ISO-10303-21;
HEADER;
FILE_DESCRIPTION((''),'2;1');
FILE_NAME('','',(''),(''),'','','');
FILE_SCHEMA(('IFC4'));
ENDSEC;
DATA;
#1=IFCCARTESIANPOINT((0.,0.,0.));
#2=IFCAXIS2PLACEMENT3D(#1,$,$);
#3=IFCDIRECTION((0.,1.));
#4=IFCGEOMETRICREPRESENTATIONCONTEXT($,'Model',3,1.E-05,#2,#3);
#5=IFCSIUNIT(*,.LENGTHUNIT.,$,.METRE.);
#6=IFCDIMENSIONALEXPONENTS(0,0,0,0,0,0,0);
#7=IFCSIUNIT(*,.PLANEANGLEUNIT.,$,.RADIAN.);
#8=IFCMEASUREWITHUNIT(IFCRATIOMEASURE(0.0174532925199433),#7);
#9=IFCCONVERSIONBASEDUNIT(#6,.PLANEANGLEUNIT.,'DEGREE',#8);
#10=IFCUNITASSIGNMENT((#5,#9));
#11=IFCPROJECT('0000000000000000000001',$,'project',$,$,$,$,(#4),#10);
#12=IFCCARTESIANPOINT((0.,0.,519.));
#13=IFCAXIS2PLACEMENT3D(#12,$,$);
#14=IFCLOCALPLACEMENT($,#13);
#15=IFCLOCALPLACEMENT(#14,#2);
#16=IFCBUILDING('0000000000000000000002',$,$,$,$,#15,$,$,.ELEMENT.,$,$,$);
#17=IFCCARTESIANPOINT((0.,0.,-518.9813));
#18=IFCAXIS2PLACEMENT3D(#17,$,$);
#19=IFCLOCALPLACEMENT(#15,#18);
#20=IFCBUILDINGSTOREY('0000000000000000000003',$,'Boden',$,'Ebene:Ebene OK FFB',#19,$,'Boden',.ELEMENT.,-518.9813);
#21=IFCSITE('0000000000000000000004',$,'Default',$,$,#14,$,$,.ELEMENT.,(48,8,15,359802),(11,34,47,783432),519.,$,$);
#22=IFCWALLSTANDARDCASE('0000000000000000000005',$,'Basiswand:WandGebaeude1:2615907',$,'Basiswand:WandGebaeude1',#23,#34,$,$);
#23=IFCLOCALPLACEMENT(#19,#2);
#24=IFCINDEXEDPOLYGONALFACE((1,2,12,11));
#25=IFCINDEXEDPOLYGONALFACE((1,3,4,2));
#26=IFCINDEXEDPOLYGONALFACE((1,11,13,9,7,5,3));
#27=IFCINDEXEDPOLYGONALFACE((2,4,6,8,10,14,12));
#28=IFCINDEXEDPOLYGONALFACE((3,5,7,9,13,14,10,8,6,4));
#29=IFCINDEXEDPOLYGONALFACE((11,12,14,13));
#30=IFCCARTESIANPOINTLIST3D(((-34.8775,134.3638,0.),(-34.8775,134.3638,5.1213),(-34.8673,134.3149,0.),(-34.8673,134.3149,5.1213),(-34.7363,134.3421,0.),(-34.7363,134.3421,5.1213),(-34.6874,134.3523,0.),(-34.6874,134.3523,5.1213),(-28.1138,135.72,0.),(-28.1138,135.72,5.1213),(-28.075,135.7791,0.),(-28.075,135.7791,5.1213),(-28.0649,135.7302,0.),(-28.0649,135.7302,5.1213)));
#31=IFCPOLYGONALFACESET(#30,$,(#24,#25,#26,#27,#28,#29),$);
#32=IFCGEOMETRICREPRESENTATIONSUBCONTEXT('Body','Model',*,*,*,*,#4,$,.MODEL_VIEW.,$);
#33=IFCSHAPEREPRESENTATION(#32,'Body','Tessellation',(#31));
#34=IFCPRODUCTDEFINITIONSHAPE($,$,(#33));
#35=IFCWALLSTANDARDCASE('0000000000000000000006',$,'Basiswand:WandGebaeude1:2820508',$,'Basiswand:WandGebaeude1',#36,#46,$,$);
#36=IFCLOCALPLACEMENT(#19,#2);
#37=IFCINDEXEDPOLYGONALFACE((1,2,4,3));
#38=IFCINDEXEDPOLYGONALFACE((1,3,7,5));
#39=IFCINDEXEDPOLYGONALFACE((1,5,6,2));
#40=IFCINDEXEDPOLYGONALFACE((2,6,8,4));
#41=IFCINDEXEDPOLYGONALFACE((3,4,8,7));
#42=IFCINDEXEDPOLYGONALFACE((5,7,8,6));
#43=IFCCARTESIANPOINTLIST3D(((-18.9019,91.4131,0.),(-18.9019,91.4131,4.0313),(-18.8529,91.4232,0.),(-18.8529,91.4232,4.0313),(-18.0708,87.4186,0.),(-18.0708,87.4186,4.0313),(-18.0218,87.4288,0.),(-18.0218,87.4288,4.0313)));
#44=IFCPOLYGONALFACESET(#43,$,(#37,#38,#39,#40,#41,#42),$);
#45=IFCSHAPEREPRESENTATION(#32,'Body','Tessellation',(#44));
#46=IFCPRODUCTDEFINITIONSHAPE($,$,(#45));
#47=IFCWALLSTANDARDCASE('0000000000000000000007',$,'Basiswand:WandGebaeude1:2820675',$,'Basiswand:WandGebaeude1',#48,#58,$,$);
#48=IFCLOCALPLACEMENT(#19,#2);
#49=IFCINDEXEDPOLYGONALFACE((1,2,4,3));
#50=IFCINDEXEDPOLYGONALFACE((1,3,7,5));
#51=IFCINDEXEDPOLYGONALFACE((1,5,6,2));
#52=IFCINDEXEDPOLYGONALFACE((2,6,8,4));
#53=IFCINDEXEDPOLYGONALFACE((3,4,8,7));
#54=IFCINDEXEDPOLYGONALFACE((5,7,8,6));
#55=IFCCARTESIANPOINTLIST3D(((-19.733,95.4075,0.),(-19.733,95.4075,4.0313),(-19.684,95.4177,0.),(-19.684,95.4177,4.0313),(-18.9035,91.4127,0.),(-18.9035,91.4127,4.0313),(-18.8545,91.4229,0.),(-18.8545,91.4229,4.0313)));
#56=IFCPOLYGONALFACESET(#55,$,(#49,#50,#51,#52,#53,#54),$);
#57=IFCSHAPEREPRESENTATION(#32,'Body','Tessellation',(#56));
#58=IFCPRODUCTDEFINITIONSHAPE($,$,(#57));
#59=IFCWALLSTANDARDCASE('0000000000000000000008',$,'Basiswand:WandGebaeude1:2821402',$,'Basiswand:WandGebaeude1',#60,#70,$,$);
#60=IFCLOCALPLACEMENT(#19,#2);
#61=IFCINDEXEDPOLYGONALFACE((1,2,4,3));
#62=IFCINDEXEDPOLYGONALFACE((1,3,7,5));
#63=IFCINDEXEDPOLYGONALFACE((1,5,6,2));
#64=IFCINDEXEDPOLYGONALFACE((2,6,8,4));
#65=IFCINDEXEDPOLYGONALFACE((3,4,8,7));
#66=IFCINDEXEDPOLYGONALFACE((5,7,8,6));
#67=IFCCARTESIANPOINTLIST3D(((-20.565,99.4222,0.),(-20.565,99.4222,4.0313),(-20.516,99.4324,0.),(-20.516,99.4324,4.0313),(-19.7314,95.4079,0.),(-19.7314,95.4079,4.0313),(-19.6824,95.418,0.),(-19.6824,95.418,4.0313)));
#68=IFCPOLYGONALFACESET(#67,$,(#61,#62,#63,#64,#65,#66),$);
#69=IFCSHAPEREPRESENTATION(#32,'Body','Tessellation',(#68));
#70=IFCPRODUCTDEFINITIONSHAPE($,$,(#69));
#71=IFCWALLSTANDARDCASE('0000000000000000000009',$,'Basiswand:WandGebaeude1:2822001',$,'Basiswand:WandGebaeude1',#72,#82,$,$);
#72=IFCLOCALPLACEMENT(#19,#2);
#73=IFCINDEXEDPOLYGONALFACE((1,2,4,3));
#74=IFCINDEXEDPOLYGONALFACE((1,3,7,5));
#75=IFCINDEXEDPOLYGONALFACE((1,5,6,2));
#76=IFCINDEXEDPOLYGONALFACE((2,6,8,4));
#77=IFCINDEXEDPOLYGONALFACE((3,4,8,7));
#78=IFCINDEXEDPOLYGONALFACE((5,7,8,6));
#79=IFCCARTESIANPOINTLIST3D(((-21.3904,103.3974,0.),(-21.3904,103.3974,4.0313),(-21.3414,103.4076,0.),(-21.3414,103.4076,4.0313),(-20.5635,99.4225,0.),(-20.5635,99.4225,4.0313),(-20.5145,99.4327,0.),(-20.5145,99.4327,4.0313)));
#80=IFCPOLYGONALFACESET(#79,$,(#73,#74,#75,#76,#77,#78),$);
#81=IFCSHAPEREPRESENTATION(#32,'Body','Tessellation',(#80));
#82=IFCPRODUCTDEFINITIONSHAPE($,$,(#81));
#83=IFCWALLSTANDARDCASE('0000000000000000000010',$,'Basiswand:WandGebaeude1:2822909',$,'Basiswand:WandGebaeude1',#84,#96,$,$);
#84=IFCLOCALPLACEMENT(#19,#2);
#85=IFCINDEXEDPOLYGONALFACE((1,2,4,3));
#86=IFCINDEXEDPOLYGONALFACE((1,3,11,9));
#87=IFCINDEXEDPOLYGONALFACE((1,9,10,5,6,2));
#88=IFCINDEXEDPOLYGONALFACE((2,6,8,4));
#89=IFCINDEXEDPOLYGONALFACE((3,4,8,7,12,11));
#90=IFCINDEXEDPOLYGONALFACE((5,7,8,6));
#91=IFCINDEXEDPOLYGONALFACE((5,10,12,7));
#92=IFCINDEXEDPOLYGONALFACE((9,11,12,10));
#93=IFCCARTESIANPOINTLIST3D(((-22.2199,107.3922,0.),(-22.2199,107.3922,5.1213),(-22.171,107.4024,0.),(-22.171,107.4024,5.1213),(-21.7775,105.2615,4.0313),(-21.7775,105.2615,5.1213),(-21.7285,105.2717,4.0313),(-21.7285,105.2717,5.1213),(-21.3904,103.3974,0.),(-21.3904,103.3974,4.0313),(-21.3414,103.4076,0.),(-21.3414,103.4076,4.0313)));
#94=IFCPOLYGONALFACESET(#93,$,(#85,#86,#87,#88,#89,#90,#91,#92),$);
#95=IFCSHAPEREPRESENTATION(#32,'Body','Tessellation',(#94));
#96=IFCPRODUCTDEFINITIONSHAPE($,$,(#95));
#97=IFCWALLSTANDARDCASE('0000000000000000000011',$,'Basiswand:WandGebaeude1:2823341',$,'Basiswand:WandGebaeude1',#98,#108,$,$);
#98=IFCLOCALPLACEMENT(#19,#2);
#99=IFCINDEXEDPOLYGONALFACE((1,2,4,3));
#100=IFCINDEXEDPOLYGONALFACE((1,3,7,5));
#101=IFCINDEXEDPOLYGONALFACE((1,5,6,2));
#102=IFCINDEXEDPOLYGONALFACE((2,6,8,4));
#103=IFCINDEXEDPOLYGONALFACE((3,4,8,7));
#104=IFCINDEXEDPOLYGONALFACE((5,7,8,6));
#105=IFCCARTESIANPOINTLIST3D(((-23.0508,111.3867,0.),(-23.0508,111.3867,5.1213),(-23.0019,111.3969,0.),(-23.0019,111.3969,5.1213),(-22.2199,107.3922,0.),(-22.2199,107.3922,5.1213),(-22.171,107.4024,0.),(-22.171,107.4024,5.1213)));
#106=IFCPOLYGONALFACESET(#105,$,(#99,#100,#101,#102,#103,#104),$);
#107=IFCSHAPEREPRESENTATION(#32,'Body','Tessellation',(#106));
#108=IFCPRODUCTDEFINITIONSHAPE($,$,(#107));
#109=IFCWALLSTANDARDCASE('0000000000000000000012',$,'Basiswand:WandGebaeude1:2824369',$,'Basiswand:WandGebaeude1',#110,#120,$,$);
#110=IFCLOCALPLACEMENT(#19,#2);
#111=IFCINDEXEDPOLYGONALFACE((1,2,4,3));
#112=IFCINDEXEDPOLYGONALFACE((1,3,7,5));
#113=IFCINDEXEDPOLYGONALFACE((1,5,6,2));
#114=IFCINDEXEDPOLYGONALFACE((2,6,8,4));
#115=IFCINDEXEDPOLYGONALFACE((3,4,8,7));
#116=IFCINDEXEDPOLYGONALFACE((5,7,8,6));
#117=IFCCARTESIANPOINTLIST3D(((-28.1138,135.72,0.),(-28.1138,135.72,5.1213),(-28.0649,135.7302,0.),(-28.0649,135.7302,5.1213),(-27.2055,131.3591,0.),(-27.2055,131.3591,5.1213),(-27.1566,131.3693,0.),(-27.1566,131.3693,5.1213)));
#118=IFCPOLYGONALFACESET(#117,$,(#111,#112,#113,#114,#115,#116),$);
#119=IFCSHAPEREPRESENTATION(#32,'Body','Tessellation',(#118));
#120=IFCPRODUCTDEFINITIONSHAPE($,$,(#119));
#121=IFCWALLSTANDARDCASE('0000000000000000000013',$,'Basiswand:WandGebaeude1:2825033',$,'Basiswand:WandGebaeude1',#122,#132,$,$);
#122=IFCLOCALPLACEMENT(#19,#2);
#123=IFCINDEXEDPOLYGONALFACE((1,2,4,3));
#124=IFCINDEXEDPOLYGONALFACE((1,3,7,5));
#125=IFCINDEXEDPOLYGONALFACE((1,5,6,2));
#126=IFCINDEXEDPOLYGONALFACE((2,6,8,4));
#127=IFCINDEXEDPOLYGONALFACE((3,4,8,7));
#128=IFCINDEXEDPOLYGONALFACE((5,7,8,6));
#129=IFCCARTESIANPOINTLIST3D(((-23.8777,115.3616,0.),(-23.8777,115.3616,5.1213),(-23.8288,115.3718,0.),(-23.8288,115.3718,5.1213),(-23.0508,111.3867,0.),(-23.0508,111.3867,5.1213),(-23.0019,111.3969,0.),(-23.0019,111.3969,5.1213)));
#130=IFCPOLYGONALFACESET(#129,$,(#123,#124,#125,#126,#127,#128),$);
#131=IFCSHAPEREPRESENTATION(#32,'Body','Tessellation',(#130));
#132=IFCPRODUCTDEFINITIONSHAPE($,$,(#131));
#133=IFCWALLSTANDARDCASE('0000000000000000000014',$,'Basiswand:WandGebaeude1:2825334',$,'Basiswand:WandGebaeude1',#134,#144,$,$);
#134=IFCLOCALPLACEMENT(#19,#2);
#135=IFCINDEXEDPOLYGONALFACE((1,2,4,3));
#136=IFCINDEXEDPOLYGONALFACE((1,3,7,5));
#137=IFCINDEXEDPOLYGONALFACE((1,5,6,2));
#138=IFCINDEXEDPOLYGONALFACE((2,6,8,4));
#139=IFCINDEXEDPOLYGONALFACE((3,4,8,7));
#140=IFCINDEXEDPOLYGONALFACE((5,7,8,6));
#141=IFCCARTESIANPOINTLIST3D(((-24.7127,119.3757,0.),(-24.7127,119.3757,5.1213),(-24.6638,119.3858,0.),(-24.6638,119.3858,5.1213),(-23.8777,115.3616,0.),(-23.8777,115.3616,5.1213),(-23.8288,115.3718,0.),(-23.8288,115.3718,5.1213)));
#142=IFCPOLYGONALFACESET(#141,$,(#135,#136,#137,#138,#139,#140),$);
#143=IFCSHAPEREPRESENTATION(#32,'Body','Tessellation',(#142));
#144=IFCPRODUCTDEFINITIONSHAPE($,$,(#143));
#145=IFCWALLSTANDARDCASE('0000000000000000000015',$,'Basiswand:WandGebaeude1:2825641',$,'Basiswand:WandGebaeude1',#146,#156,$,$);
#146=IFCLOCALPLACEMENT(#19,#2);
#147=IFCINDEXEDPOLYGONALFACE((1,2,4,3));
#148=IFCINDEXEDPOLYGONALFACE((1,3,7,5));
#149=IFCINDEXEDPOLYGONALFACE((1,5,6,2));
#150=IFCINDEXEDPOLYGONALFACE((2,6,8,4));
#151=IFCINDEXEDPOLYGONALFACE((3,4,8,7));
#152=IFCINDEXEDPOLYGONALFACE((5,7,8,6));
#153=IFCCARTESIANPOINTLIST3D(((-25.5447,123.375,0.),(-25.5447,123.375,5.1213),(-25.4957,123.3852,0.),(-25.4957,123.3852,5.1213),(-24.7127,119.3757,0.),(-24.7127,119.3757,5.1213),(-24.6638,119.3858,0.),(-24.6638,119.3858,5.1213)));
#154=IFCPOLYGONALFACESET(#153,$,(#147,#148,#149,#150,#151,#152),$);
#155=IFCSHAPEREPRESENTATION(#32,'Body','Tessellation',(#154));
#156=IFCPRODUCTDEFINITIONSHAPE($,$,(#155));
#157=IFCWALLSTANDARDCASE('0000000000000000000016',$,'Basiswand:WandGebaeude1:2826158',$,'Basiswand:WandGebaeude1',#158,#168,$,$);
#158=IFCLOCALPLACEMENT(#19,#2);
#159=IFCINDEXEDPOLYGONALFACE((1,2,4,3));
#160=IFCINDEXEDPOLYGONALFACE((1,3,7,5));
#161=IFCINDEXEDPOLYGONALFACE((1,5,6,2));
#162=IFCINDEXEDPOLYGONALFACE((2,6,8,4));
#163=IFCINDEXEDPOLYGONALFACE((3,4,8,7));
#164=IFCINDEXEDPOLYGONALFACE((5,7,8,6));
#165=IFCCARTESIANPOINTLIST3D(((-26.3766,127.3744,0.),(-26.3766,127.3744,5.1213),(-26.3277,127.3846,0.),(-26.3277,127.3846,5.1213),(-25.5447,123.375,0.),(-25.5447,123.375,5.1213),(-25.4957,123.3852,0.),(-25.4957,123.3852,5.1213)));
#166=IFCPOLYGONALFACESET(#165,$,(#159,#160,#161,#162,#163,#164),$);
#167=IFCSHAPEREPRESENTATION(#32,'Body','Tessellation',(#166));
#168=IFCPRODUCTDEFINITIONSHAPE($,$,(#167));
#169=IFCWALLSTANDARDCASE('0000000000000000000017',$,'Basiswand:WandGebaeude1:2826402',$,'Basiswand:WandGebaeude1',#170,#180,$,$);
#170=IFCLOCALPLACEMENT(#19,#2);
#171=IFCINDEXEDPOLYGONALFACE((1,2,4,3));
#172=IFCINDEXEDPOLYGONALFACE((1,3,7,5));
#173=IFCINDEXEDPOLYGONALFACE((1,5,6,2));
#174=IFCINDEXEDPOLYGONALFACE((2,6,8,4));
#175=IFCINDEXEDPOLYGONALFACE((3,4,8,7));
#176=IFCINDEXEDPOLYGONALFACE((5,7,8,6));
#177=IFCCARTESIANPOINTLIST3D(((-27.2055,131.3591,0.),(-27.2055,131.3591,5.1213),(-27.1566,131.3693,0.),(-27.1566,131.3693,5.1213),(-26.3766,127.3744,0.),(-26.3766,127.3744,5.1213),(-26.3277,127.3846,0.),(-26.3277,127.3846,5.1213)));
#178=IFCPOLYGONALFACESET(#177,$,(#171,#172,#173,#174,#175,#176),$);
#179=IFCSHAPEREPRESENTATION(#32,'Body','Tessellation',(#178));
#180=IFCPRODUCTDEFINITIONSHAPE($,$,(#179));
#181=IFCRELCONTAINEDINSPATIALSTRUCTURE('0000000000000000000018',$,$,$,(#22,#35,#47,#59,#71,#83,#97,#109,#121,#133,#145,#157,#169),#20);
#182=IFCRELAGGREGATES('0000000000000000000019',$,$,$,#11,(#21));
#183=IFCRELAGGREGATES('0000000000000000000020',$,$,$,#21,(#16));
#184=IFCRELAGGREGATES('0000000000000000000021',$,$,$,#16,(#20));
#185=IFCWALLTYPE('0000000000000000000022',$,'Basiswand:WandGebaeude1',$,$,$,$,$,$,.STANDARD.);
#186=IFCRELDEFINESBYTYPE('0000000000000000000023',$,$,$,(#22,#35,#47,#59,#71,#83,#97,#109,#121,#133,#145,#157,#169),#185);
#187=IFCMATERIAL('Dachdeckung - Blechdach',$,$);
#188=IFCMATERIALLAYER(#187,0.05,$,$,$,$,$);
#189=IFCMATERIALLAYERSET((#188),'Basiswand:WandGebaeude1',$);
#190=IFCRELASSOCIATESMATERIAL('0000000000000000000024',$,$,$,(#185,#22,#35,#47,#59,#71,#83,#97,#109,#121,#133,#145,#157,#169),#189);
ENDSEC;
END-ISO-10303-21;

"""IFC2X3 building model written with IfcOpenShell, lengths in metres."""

from ifc_helpers import new_model, entity, si_unit, converted_unit, direction, frame, frame_2d, origin, place, context, subcontext, project, spatial, polyline, rectangle, outline, extrude, material, layer, layer_set, layer_usage, type_object, element, save


model = new_model("IFC2X3")

# Units and contexts
model_context = context("Model", 3, precision=1e-05, world=origin(), true_north=direction((0.0, 1.0)))
body_context = subcontext(model_context, "Body", "Model", "MODEL_VIEW")
ifc_project = project(units=[si_unit("LENGTHUNIT", "METRE"), converted_unit("PLANEANGLEUNIT", "DEGREE", entity("IfcRatioMeasure", 0.0174532925199433), si_unit("PLANEANGLEUNIT", "RADIAN"), dimensions=[0, 0, 0, 0, 0, 0, 0])], contexts=[model_context])

# Site, building, storey
site_placement = place(None, frame((0.0, 0.0, 519.0)))
site = spatial("IfcSite", under=ifc_project, at=site_placement, Name="Default", CompositionType="ELEMENT", RefLatitude=(48, 8, 15, 359802), RefLongitude=(11, 34, 47, 783432), RefElevation=519.0)
building_placement = place(site_placement, origin())
building = spatial("IfcBuilding", under=site, at=building_placement, CompositionType="ELEMENT")
storey_placement = place(building_placement, frame((0.0, 0.0, -518.9813)))
storey = spatial("IfcBuildingStorey", under=building, at=storey_placement, Name="Boden", ObjectType="Ebene:Ebene OK FFB", LongName="Boden", CompositionType="ELEMENT", Elevation=-518.9813)

# Walls
ifc_material_1 = material(Name="Dachdeckung - Blechdach")
ifc_layer_1 = layer(ifc_material_1, 0.05)
ifc_layer_set_1 = layer_set([ifc_layer_1], Name="Basiswand:WandGebaeude1")
ifc_layer_usage_1 = layer_usage(ifc_layer_set_1, "AXIS2", "NEGATIVE", 0.025)
wall_type_1 = type_object("IfcWallType", Name="Basiswand:WandGebaeude1", PredefinedType="STANDARD", material=ifc_layer_set_1)
wall_1_placement = place(storey_placement, frame((-34.8724, 134.3393, 0.0), z_axis=(0.0, 0.0, 1.0), x_axis=(0.979034, 0.203696, 0.0)))
element("IfcWallStandardCase", 1, at=wall_1_placement, inside=storey, type_object=wall_type_1, material=ifc_layer_usage_1, Name="Basiswand:WandGebaeude1:2615907", ObjectType="Basiswand:WandGebaeude1", context=body_context, shape_type="SweptSolid", body=[
    extrude(outline(polyline([(6.9481, -0.025), (6.9481, 0.025), (0.0, 0.025), (0.0, -0.025), (0.1338, -0.025), (0.1838, -0.025), (6.8981, -0.025), (6.9481, -0.025)])), origin(), (0.0, 0.0, 1.0), 5.1213),
])
ifc_layer_usage_2 = layer_usage(ifc_layer_set_1, "AXIS2", "NEGATIVE", 0.025)
wall_2_placement = place(storey_placement, frame((-18.0463, 87.4237, 0.0), z_axis=(0.0, 0.0, 1.0), x_axis=(-0.203696, 0.979034, 0.0)))
element("IfcWallStandardCase", 2, at=wall_2_placement, inside=storey, type_object=wall_type_1, material=ifc_layer_usage_2, Name="Basiswand:WandGebaeude1:2820508", ObjectType="Basiswand:WandGebaeude1", context=body_context, shape_type="SweptSolid", body=[
    extrude(rectangle(XDim=4.08, YDim=0.05, at=frame_2d((2.04, 0.0), x_axis=(-1.0, 0.0))), origin(), (0.0, 0.0, 1.0), 4.0313),
])
ifc_layer_usage_3 = layer_usage(ifc_layer_set_1, "AXIS2", "NEGATIVE", 0.025)
wall_3_placement = place(storey_placement, frame((-18.879, 91.4178, 0.0), z_axis=(0.0, 0.0, 1.0), x_axis=(-0.203311, 0.979114, 0.0)))
element("IfcWallStandardCase", 3, at=wall_3_placement, inside=storey, type_object=wall_type_1, material=ifc_layer_usage_3, Name="Basiswand:WandGebaeude1:2820675", ObjectType="Basiswand:WandGebaeude1", context=body_context, shape_type="SweptSolid", body=[
    extrude(rectangle(XDim=4.08, YDim=0.05, at=frame_2d((2.04, 0.0), x_axis=(-1.0, 0.0))), origin(), (0.0, 0.0, 1.0), 4.0313),
])
ifc_layer_usage_4 = layer_usage(ifc_layer_set_1, "AXIS2", "NEGATIVE", 0.025)
wall_4_placement = place(storey_placement, frame((-19.7069, 95.4129, 0.0), z_axis=(0.0, 0.0, 1.0), x_axis=(-0.203311, 0.979114, 0.0)))
element("IfcWallStandardCase", 4, at=wall_4_placement, inside=storey, type_object=wall_type_1, material=ifc_layer_usage_4, Name="Basiswand:WandGebaeude1:2821402", ObjectType="Basiswand:WandGebaeude1", context=body_context, shape_type="SweptSolid", body=[
    extrude(rectangle(XDim=4.1, YDim=0.05, at=frame_2d((2.05, 0.0), x_axis=(-1.0, 0.0))), origin(), (0.0, 0.0, 1.0), 4.0313),
])
ifc_layer_usage_5 = layer_usage(ifc_layer_set_1, "AXIS2", "NEGATIVE", 0.025)
wall_5_placement = place(storey_placement, frame((-20.539, 99.4276, 0.0), z_axis=(0.0, 0.0, 1.0), x_axis=(-0.203676, 0.979038, 0.0)))
element("IfcWallStandardCase", 5, at=wall_5_placement, inside=storey, type_object=wall_type_1, material=ifc_layer_usage_5, Name="Basiswand:WandGebaeude1:2822001", ObjectType="Basiswand:WandGebaeude1", context=body_context, shape_type="SweptSolid", body=[
    extrude(rectangle(XDim=4.06, YDim=0.05, at=frame_2d((2.03, 0.0), x_axis=(-1.0, 0.0))), origin(), (0.0, 0.0, 1.0), 4.0313),
])

# Wall, opening
ifc_layer_usage_6 = layer_usage(ifc_layer_set_1, "AXIS2", "NEGATIVE", 0.025)
wall_6_placement = place(storey_placement, frame((-21.3659, 103.4025, 0.0), z_axis=(0.0, 0.0, 1.0), x_axis=(-0.203311, 0.979114, 0.0)))
wall_6 = element("IfcWallStandardCase", 6, at=wall_6_placement, inside=storey, type_object=wall_type_1, material=ifc_layer_usage_6, Name="Basiswand:WandGebaeude1:2822909", ObjectType="Basiswand:WandGebaeude1", context=body_context, shape_type="SweptSolid", body=[
    extrude(rectangle(XDim=4.08, YDim=0.05, at=frame_2d((2.04, 0.0), x_axis=(-1.0, 0.0))), origin(), (0.0, 0.0, 1.0), 5.1213),
])
opening_placement = place(wall_6_placement, origin())
element("IfcOpeningElement", 7, at=opening_placement, cuts=wall_6, ObjectType="Opening", context=body_context, shape_type="SweptSolid", body=[
    extrude(rectangle(XDim=1.09, YDim=1.9038, at=frame_2d((0.0, 0.0), x_axis=(0.0, 1.0))), frame((0.9519, 0.025, 4.5763), z_axis=(0.0, -1.0, 0.0), x_axis=(-1.0, 0.0, 0.0)), (0.0, 0.0, 1.0), 0.05),
])

# Walls
ifc_layer_usage_7 = layer_usage(ifc_layer_set_1, "AXIS2", "NEGATIVE", 0.025)
wall_7_placement = place(storey_placement, frame((-22.1954, 107.3973, 0.0), z_axis=(0.0, 0.0, 1.0), x_axis=(-0.203662, 0.979041, 0.0)))
element("IfcWallStandardCase", 8, at=wall_7_placement, inside=storey, type_object=wall_type_1, material=ifc_layer_usage_7, Name="Basiswand:WandGebaeude1:2823341", ObjectType="Basiswand:WandGebaeude1", context=body_context, shape_type="SweptSolid", body=[
    extrude(rectangle(XDim=4.08, YDim=0.05, at=frame_2d((2.04, 0.0), x_axis=(-1.0, 0.0))), origin(), (0.0, 0.0, 1.0), 5.1213),
])
ifc_layer_usage_8 = layer_usage(ifc_layer_set_1, "AXIS2", "NEGATIVE", 0.025)
wall_8_placement = place(storey_placement, frame((-27.1811, 131.3642, 0.0), z_axis=(0.0, 0.0, 1.0), x_axis=(-0.203899, 0.978992, 0.0)))
element("IfcWallStandardCase", 9, at=wall_8_placement, inside=storey, type_object=wall_type_1, material=ifc_layer_usage_8, Name="Basiswand:WandGebaeude1:2824369", ObjectType="Basiswand:WandGebaeude1", context=body_context, shape_type="SweptSolid", body=[
    extrude(outline(polyline([(4.4544, -0.025), (4.4544, 0.025), (0.0, 0.025), (0.0, -0.025), (4.4544, -0.025)])), origin(), (0.0, 0.0, 1.0), 5.1213),
])
ifc_layer_usage_9 = layer_usage(ifc_layer_set_1, "AXIS2", "NEGATIVE", 0.025)
wall_9_placement = place(storey_placement, frame((-23.0264, 111.3918, 0.0), z_axis=(0.0, 0.0, 1.0), x_axis=(-0.203662, 0.979041, 0.0)))
element("IfcWallStandardCase", 10, at=wall_9_placement, inside=storey, type_object=wall_type_1, material=ifc_layer_usage_9, Name="Basiswand:WandGebaeude1:2825033", ObjectType="Basiswand:WandGebaeude1", context=body_context, shape_type="SweptSolid", body=[
    extrude(rectangle(XDim=4.06, YDim=0.05, at=frame_2d((2.03, 0.0), x_axis=(-1.0, 0.0))), origin(), (0.0, 0.0, 1.0), 5.1213),
])
ifc_layer_usage_10 = layer_usage(ifc_layer_set_1, "AXIS2", "NEGATIVE", 0.025)
wall_10_placement = place(storey_placement, frame((-23.8532, 115.3667, 0.0), z_axis=(0.0, 0.0, 1.0), x_axis=(-0.203662, 0.979041, 0.0)))
element("IfcWallStandardCase", 11, at=wall_10_placement, inside=storey, type_object=wall_type_1, material=ifc_layer_usage_10, Name="Basiswand:WandGebaeude1:2825334", ObjectType="Basiswand:WandGebaeude1", context=body_context, shape_type="SweptSolid", body=[
    extrude(rectangle(XDim=4.1, YDim=0.05, at=frame_2d((2.05, 0.0), x_axis=(-1.0, 0.0))), origin(), (0.0, 0.0, 1.0), 5.1213),
])
ifc_layer_usage_11 = layer_usage(ifc_layer_set_1, "AXIS2", "NEGATIVE", 0.025)
wall_11_placement = place(storey_placement, frame((-24.6882, 119.3808, 0.0), z_axis=(0.0, 0.0, 1.0), x_axis=(-0.203662, 0.979041, 0.0)))
element("IfcWallStandardCase", 12, at=wall_11_placement, inside=storey, type_object=wall_type_1, material=ifc_layer_usage_11, Name="Basiswand:WandGebaeude1:2825641", ObjectType="Basiswand:WandGebaeude1", context=body_context, shape_type="SweptSolid", body=[
    extrude(rectangle(XDim=4.085, YDim=0.05, at=frame_2d((2.0425, 0.0), x_axis=(-1.0, 0.0))), origin(), (0.0, 0.0, 1.0), 5.1213),
])
ifc_layer_usage_12 = layer_usage(ifc_layer_set_1, "AXIS2", "NEGATIVE", 0.025)
wall_12_placement = place(storey_placement, frame((-25.5202, 123.3801, 0.0), z_axis=(0.0, 0.0, 1.0), x_axis=(-0.203662, 0.979041, 0.0)))
element("IfcWallStandardCase", 13, at=wall_12_placement, inside=storey, type_object=wall_type_1, material=ifc_layer_usage_12, Name="Basiswand:WandGebaeude1:2826158", ObjectType="Basiswand:WandGebaeude1", context=body_context, shape_type="SweptSolid", body=[
    extrude(rectangle(XDim=4.085, YDim=0.05, at=frame_2d((2.0425, 0.0), x_axis=(-1.0, 0.0))), origin(), (0.0, 0.0, 1.0), 5.1213),
])
ifc_layer_usage_13 = layer_usage(ifc_layer_set_1, "AXIS2", "NEGATIVE", 0.025)
wall_13_placement = place(storey_placement, frame((-26.3522, 127.3795, 0.0), z_axis=(0.0, 0.0, 1.0), x_axis=(-0.203662, 0.979041, 0.0)))
element("IfcWallStandardCase", 14, at=wall_13_placement, inside=storey, type_object=wall_type_1, material=ifc_layer_usage_13, Name="Basiswand:WandGebaeude1:2826402", ObjectType="Basiswand:WandGebaeude1", context=body_context, shape_type="SweptSolid", body=[
    extrude(rectangle(XDim=4.07, YDim=0.05, at=frame_2d((2.035, 0.0), x_axis=(-1.0, 0.0))), origin(), (0.0, 0.0, 1.0), 5.1213),
])

save(model, "model.ifc")
